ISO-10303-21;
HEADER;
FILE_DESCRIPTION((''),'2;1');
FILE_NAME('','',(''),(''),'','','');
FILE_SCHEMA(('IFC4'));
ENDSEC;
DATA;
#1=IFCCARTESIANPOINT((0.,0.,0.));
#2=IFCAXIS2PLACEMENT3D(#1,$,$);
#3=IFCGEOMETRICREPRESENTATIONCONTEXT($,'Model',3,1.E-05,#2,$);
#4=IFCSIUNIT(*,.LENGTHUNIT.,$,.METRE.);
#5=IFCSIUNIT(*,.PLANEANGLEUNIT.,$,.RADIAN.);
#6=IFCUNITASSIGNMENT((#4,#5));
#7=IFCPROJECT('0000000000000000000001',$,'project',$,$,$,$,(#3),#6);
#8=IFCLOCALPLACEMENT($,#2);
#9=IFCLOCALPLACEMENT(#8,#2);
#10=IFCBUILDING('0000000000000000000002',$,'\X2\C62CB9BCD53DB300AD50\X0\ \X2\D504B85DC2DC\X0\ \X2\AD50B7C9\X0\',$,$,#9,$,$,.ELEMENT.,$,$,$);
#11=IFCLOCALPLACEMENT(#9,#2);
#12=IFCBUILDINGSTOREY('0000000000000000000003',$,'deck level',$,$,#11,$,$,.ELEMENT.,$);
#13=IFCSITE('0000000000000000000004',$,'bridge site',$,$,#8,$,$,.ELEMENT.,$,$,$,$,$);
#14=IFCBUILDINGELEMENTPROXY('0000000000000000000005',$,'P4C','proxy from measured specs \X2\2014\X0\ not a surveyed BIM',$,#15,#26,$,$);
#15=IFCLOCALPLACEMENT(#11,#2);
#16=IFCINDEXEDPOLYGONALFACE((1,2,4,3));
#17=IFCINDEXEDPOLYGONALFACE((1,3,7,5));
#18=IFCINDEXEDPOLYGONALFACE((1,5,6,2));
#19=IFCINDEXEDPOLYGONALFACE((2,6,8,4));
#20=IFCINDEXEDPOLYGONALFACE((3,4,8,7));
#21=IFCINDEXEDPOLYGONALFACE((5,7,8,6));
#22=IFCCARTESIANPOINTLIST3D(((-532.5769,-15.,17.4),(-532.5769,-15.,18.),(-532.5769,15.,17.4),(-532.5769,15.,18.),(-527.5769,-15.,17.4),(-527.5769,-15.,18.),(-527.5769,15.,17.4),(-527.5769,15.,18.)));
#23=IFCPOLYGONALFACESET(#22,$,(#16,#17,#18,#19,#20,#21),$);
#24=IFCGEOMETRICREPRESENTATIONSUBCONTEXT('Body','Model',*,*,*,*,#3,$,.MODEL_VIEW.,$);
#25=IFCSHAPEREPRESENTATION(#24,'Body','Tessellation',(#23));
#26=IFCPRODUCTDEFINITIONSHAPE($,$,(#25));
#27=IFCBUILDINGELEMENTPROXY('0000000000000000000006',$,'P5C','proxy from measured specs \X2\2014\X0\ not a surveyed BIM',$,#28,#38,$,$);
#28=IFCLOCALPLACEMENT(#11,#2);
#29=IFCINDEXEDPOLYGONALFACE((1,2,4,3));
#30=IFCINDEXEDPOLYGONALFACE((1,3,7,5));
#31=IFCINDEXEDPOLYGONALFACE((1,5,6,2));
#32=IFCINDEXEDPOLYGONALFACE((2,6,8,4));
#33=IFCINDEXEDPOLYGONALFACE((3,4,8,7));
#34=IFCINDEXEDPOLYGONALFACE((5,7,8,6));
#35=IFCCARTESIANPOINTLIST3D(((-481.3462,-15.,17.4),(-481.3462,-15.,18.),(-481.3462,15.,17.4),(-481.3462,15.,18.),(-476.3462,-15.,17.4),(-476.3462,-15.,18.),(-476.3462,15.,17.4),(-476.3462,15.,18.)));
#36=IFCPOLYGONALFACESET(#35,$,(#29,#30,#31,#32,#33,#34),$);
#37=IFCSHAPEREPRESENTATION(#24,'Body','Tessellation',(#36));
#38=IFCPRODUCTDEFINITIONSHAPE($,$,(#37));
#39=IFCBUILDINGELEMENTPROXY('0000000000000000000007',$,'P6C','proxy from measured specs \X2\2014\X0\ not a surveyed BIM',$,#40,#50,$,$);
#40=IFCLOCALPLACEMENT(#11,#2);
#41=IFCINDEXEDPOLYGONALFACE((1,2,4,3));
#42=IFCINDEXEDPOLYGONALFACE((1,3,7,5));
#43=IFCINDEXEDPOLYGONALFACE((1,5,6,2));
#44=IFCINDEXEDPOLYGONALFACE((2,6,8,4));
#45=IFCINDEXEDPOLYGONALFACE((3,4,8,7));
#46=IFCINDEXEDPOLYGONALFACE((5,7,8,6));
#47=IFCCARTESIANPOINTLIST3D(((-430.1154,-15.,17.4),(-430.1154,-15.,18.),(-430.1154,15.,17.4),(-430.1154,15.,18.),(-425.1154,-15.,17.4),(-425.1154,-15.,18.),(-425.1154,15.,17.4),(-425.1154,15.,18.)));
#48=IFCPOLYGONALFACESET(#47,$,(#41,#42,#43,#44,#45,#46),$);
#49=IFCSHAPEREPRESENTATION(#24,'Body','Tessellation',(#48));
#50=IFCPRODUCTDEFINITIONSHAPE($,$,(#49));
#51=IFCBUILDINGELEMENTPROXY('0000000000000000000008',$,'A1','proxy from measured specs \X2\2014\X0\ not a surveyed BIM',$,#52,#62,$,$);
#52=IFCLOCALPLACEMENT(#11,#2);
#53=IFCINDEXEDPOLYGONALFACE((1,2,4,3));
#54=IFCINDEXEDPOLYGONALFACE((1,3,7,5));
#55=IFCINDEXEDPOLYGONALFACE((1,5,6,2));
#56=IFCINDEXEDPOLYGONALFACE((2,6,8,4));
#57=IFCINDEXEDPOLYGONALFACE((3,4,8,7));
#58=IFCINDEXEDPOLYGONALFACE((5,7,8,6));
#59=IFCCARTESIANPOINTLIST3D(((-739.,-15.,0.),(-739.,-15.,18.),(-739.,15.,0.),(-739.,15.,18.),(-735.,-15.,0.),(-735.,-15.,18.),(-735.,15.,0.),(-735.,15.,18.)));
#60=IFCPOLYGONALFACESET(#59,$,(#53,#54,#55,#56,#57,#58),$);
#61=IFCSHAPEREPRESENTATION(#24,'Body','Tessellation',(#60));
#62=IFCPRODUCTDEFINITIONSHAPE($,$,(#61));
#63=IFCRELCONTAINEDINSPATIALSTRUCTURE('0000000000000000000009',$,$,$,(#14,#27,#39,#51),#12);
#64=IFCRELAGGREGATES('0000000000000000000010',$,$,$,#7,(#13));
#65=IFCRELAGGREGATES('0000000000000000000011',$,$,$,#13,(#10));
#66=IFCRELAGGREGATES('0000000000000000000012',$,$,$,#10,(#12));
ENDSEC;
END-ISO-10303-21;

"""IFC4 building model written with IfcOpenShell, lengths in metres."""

from ifc_helpers import new_model, si_unit, frame, origin, origin_2d, place, context, subcontext, project, spatial, rectangle, extrude, element, save


model = new_model("IFC4")

# Units and contexts
model_context = context("Model", 3, precision=1e-05, world=origin())
body_context = subcontext(model_context, "Body", "Model", "MODEL_VIEW")
ifc_project = project(units=[si_unit("LENGTHUNIT", "METRE"), si_unit("PLANEANGLEUNIT", "RADIAN")], contexts=[model_context])

# Site, building, storey
site_placement = place(None, origin())
site = spatial("IfcSite", under=ifc_project, at=site_placement, Name="bridge site", CompositionType="ELEMENT")
building_placement = place(site_placement, origin())
building = spatial("IfcBuilding", under=site, at=building_placement, Name="올림픽대교 프록시 교량", CompositionType="ELEMENT")
storey_placement = place(building_placement, origin())
storey = spatial("IfcBuildingStorey", under=building, at=storey_placement, Name="deck level", CompositionType="ELEMENT")

# Building element proxies
for number, where, name in (
    (1, (-530.0769, 0.0, 17.4), "P4C"),
    (2, (-478.8462, 0.0, 17.4), "P5C"),
    (3, (-427.6154, 0.0, 17.4), "P6C"),
):
    element("IfcBuildingElementProxy", number, at=place(storey_placement, frame(where)), inside=storey, Name=name, Description="proxy from measured specs — not a surveyed BIM", context=body_context, shape_type="SweptSolid", body=[
        extrude(rectangle(XDim=5.0, YDim=30.0, at=origin_2d()), origin(), (0.0, 0.0, 1.0), 0.6),
    ])
proxy_placement = place(storey_placement, frame((-737.0, 0.0, 0.0)))
element("IfcBuildingElementProxy", 4, at=proxy_placement, inside=storey, Name="A1", Description="proxy from measured specs — not a surveyed BIM", context=body_context, shape_type="SweptSolid", body=[
    extrude(rectangle(XDim=4.0, YDim=30.0, at=origin_2d()), origin(), (0.0, 0.0, 1.0), 18.0),
])

save(model, "model.ifc")
